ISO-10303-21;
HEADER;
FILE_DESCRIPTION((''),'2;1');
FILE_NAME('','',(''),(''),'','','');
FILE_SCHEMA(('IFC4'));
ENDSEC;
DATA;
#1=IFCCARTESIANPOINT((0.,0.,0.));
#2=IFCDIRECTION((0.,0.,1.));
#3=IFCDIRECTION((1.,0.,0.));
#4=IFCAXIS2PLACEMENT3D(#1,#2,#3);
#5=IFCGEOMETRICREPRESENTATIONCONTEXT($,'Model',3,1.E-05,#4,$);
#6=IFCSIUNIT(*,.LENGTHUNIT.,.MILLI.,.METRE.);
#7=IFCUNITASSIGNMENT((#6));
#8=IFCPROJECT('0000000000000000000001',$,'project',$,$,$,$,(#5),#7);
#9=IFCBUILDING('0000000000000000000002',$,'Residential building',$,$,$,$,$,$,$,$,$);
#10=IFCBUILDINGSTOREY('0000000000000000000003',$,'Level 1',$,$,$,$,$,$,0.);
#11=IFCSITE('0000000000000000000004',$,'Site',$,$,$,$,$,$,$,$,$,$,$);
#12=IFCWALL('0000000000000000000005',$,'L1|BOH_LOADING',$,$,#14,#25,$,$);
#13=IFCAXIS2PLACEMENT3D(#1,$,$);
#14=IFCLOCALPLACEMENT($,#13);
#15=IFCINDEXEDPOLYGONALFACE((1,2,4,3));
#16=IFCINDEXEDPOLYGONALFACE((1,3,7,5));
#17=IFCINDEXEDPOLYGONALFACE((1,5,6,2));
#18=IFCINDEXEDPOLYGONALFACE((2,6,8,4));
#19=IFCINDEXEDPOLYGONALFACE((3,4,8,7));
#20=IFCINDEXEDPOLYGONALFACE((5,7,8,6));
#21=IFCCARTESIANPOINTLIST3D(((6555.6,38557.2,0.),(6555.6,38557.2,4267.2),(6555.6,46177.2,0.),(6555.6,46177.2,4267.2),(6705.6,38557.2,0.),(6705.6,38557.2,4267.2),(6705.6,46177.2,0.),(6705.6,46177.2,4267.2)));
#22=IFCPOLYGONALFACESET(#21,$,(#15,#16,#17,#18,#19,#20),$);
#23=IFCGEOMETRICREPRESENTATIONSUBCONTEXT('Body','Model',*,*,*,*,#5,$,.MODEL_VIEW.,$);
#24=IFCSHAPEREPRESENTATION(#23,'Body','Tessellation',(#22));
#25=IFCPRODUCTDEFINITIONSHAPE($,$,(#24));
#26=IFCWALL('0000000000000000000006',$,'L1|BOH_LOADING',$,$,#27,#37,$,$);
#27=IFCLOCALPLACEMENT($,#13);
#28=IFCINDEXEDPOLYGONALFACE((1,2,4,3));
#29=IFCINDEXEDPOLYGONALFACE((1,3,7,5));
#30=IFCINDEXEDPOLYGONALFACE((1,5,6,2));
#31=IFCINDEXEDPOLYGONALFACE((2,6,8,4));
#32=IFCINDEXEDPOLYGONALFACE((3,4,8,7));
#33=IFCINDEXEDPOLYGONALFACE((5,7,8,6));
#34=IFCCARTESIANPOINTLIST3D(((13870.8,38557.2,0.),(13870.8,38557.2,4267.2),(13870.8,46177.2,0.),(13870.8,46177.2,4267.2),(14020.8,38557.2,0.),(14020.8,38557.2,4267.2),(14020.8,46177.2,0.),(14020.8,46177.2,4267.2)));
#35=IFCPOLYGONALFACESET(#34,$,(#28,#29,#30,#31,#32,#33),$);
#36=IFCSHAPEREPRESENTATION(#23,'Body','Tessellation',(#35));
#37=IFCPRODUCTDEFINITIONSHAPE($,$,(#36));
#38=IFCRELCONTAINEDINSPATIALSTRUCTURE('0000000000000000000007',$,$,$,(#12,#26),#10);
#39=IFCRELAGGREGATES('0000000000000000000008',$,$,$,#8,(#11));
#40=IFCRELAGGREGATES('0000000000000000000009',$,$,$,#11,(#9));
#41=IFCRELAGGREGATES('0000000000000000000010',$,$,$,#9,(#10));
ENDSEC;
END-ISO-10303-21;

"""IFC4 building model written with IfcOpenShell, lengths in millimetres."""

from ifc_helpers import new_model, si_unit, frame, origin_with_axes, place, context, subcontext, project, spatial, indexed_curve, outline, extrude, element, save


model = new_model("IFC4")

# Units and contexts
model_context = context("Model", 3, precision=1e-05, world=origin_with_axes())
body_context = subcontext(model_context, "Body", "Model", "MODEL_VIEW")
ifc_project = project(units=[si_unit("LENGTHUNIT", "METRE", prefix="MILLI")], contexts=[model_context])

# Site, building, storey
site = spatial("IfcSite", under=ifc_project, Name="Site")
building = spatial("IfcBuilding", under=site, Name="Residential building")
storey = spatial("IfcBuildingStorey", under=building, Name="Level 1", Elevation=0.0)

# Walls
for number, where, z_axis, x_axis, name in (
    (1, (6705.6, 38557.2, 0.0), (0.0, 0.0, 1.0), (0.0, 1.0, 0.0), "L1|BOH_LOADING"),
    (2, (14020.8, 38557.2, 0.0), (0.0, 0.0, 1.0), (0.0, 1.0, 0.0), "L1|BOH_LOADING"),
):
    element("IfcWall", number, at=place(None, frame(where, z_axis=z_axis, x_axis=x_axis)), inside=storey, Name=name, context=body_context, shape_type="SweptSolid", body=[
        extrude(outline(indexed_curve([(0.0, 0.0), (0.0, 150.0), (7620.0, 150.0), (7620.0, 0.0), (0.0, 0.0)], self_intersect=False)), origin_with_axes(), (0.0, 0.0, 1.0), 4267.2),
    ])

save(model, "model.ifc")
